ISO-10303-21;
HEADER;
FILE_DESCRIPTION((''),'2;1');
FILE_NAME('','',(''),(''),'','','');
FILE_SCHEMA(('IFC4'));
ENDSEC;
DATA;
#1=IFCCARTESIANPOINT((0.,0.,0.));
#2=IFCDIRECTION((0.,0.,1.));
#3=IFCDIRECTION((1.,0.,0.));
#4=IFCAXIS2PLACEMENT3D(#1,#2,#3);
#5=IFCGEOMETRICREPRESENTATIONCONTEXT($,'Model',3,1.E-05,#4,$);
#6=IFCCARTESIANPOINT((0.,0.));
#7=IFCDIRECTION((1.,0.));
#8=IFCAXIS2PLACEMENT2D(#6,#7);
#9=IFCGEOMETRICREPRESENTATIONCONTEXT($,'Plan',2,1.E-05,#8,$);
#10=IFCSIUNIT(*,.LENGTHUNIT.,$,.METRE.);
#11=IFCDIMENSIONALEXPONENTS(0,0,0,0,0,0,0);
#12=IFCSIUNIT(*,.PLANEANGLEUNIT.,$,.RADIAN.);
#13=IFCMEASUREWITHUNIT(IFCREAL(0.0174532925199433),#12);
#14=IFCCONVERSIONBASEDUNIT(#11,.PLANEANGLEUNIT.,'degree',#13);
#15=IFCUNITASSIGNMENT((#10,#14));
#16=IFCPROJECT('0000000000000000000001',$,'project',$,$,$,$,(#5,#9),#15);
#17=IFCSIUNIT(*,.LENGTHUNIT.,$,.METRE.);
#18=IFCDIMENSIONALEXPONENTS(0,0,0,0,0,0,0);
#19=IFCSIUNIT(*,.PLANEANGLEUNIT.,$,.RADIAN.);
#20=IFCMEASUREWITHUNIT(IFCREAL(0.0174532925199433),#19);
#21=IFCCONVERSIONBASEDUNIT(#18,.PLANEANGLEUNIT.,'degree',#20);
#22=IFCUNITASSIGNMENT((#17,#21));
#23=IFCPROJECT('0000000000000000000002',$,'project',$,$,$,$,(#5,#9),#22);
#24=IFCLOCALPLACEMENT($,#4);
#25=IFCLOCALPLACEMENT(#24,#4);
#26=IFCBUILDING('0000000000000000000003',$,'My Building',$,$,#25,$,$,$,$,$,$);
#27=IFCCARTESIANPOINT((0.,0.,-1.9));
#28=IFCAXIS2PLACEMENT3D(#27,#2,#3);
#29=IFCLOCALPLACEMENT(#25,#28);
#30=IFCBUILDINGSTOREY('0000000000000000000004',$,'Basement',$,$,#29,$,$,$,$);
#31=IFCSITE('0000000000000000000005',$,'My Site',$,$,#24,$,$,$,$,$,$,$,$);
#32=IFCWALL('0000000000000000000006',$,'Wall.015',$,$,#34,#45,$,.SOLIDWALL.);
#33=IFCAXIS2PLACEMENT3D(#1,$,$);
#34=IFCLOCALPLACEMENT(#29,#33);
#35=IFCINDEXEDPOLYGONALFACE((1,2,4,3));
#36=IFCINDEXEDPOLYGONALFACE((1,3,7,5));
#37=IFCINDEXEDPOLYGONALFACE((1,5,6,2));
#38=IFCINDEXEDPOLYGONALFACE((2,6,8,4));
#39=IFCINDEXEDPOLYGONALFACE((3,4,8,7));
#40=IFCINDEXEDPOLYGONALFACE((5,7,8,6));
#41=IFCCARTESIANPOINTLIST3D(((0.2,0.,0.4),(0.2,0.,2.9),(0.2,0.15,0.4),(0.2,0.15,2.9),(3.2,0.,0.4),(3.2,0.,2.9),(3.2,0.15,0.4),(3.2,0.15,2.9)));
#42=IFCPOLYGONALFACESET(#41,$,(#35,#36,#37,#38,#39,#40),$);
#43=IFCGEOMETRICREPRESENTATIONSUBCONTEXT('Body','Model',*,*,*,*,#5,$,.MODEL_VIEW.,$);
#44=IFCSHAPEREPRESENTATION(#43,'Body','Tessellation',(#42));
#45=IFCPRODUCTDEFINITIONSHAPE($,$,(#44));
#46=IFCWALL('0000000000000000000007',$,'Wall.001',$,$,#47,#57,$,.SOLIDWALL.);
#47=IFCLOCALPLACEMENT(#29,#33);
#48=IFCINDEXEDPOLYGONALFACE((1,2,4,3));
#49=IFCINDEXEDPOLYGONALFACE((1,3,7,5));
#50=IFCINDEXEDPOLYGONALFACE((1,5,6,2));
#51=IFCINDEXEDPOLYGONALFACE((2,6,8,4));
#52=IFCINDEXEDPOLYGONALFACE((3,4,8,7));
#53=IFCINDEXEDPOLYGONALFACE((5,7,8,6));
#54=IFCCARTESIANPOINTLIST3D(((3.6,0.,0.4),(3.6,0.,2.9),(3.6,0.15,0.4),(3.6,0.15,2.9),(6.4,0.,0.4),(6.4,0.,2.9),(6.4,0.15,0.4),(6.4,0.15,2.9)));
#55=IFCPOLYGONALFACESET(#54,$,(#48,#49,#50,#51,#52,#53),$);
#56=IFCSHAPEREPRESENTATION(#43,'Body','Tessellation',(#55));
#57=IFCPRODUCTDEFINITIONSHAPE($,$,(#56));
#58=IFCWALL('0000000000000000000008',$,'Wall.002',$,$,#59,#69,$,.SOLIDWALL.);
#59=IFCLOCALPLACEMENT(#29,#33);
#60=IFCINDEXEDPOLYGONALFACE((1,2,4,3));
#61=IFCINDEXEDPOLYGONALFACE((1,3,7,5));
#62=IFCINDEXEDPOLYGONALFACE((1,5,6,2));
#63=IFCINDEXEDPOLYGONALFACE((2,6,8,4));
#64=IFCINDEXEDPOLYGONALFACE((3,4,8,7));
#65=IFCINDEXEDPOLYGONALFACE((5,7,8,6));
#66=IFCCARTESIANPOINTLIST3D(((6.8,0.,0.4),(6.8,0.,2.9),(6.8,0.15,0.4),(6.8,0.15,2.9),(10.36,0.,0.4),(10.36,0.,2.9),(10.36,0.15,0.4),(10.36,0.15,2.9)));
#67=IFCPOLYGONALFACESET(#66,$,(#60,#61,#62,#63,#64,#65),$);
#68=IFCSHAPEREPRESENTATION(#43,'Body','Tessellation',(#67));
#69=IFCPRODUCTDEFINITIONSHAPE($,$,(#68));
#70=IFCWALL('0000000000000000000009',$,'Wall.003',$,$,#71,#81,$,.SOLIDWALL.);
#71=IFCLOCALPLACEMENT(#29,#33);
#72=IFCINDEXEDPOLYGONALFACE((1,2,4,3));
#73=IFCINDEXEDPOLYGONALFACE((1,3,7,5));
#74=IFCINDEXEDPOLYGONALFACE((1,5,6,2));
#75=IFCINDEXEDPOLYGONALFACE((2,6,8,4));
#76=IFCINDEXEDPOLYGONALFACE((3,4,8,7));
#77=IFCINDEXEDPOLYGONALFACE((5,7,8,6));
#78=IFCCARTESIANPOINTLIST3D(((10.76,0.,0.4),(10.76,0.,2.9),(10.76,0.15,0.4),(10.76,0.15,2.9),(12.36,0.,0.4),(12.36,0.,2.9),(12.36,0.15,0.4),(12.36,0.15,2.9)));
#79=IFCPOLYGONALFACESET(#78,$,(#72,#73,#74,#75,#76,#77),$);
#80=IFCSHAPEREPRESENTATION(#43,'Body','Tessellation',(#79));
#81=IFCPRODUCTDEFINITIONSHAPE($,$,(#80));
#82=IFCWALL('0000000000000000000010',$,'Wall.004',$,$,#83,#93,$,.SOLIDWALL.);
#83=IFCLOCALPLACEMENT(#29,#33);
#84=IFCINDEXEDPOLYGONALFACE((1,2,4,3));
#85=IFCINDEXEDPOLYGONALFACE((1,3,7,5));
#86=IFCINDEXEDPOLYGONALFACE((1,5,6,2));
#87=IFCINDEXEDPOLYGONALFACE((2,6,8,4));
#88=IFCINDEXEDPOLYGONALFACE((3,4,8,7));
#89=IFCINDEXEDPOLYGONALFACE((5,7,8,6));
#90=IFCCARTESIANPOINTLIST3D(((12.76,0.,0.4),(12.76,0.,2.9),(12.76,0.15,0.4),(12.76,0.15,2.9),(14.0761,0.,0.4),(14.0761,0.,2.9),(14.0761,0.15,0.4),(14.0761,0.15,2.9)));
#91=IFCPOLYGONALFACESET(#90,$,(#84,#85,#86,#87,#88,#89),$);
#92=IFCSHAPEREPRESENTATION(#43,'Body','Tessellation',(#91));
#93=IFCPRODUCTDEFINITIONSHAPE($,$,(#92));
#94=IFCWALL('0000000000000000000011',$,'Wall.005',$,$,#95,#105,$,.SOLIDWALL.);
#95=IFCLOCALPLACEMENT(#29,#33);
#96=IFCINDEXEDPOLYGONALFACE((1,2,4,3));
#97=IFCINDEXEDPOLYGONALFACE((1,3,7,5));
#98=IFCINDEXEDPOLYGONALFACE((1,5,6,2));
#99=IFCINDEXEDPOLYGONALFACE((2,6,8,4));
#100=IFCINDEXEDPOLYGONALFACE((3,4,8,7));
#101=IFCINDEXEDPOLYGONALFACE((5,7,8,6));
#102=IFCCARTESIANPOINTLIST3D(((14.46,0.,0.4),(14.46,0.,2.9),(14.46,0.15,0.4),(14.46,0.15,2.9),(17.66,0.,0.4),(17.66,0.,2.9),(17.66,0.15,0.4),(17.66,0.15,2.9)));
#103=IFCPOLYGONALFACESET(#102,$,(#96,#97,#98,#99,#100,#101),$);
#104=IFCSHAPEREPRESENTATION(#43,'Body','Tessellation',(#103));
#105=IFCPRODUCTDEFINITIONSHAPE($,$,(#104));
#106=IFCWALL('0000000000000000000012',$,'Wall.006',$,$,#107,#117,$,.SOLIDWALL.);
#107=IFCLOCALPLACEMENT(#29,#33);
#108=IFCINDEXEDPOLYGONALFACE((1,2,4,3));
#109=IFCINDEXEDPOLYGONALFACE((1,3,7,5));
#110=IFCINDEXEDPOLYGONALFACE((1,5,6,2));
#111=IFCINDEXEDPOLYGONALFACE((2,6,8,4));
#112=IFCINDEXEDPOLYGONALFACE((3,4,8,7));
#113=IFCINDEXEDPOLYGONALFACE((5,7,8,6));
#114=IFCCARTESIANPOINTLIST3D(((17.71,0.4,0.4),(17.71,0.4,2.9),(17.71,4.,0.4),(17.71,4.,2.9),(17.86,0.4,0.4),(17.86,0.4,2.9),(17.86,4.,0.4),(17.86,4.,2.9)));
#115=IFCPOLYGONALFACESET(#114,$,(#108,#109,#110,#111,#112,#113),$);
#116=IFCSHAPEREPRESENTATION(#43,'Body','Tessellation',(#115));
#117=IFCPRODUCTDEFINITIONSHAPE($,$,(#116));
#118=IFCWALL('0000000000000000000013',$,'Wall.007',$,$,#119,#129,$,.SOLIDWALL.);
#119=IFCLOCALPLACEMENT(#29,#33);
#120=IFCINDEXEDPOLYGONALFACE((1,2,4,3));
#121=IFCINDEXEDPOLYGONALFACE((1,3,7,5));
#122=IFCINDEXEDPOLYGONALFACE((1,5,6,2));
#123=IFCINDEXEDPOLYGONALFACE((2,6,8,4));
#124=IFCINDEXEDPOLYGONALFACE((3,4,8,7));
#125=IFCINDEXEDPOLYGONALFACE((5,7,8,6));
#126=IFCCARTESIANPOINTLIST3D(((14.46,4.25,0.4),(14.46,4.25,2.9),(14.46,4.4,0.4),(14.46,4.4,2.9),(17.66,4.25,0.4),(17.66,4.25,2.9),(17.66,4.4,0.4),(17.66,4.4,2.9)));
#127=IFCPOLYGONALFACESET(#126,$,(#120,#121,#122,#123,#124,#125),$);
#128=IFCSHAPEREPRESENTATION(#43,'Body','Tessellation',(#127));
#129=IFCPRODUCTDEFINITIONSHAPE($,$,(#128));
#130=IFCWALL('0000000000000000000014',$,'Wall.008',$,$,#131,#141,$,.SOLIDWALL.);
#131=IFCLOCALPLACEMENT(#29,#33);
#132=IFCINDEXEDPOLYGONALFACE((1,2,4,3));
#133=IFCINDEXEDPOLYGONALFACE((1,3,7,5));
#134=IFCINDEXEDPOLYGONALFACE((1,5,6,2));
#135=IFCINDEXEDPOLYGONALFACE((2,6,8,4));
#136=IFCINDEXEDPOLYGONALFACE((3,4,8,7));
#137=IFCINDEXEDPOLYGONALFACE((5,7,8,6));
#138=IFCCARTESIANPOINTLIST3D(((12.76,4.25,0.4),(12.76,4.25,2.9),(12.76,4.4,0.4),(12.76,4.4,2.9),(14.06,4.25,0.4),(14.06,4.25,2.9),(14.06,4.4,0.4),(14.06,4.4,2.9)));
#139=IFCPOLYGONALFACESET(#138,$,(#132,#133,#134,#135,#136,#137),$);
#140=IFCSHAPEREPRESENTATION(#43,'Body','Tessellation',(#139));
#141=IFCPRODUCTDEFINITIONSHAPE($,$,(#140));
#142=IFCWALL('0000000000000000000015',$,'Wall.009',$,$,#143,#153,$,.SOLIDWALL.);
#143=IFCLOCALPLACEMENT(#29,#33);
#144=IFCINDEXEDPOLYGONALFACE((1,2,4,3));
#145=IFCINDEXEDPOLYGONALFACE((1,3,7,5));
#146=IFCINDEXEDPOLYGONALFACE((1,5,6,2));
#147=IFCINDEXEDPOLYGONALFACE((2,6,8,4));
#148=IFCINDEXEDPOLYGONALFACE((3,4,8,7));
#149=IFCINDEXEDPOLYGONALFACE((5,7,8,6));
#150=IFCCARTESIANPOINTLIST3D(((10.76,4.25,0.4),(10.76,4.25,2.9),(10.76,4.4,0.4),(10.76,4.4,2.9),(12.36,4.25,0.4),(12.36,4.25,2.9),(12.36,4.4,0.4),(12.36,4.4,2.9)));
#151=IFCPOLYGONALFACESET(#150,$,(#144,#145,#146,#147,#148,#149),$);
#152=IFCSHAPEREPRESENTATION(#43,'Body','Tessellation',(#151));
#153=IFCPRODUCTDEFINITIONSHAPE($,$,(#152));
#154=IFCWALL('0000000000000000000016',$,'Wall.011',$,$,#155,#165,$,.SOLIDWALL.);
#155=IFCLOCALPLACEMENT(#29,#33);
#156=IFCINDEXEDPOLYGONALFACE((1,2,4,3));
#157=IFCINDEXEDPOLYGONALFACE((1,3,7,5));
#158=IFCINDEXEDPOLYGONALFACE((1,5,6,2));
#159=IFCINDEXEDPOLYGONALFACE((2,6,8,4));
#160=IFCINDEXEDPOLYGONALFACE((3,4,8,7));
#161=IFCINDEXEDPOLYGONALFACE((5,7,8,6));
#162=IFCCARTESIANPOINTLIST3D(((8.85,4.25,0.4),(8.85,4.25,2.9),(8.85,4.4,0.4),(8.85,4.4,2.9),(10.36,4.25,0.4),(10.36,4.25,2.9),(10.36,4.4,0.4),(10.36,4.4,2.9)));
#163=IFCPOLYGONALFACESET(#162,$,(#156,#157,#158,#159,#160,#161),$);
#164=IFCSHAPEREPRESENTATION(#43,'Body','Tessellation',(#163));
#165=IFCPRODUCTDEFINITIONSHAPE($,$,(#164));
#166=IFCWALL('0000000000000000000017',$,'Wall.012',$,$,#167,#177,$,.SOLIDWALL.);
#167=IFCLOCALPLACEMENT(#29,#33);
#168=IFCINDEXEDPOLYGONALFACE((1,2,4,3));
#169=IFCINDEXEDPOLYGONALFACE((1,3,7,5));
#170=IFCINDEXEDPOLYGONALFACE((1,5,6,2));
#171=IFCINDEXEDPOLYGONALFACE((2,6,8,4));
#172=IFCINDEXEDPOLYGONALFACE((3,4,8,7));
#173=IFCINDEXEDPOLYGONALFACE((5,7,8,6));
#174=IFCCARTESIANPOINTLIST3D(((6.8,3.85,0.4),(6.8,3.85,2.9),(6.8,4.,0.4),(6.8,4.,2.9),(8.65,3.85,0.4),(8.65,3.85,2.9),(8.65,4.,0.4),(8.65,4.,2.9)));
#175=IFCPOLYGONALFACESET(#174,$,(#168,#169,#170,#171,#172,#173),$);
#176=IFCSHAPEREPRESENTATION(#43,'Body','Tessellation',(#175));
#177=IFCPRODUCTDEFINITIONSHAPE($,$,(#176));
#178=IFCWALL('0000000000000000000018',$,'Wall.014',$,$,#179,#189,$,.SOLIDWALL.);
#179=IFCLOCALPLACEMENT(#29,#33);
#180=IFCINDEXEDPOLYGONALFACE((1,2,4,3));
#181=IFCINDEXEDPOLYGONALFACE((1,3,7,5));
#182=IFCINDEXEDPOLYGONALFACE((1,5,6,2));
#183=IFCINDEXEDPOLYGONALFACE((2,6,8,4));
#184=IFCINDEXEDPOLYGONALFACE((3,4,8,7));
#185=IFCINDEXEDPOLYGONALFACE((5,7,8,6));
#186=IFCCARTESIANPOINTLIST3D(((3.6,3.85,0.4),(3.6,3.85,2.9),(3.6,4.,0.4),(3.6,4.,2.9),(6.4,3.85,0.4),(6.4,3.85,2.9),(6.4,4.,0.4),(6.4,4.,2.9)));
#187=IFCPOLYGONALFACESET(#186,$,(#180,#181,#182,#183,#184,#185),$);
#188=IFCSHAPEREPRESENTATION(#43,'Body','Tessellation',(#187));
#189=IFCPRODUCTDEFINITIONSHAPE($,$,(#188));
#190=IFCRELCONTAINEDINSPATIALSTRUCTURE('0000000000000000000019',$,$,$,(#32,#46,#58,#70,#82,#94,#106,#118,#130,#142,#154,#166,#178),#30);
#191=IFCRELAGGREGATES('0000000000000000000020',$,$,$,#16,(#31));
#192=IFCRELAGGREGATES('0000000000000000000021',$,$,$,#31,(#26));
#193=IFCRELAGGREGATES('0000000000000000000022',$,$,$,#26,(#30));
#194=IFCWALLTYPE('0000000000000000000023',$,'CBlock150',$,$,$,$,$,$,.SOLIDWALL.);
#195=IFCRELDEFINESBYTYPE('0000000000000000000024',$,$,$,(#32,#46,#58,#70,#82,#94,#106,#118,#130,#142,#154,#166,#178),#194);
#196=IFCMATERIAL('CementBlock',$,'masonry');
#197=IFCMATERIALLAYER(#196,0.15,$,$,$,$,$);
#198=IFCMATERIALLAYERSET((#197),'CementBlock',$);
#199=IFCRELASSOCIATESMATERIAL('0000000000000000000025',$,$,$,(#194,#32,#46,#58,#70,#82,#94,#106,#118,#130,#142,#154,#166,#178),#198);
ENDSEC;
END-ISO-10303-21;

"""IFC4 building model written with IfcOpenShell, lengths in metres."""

from ifc_helpers import new_model, entity, si_unit, converted_unit, frame, origin_with_axes, origin_2d_with_axis, place, context, subcontext, project, spatial, indexed_curve, outline, extrude, material, layer, layer_set, layer_usage, type_object, element, save


model = new_model("IFC4")

# Units and contexts
model_context = context("Model", 3, precision=1e-05, world=origin_with_axes())
plan_context = context("Plan", 2, precision=1e-05, world=origin_2d_with_axis())
body_context = subcontext(model_context, "Body", "Model", "MODEL_VIEW")
ifc_project_1 = project(units=[si_unit("LENGTHUNIT", "METRE"), converted_unit("PLANEANGLEUNIT", "degree", entity("IfcReal", 0.0174532925199433), si_unit("PLANEANGLEUNIT", "RADIAN"), dimensions=[0, 0, 0, 0, 0, 0, 0])], contexts=[model_context, plan_context])
ifc_project_2 = project(units=[si_unit("LENGTHUNIT", "METRE"), converted_unit("PLANEANGLEUNIT", "degree", entity("IfcReal", 0.0174532925199433), si_unit("PLANEANGLEUNIT", "RADIAN"), dimensions=[0, 0, 0, 0, 0, 0, 0])], contexts=[model_context, plan_context])

# Site, building, storey
site_placement = place(None, origin_with_axes())
site = spatial("IfcSite", under=ifc_project_1, at=site_placement, Name="My Site")
building_placement = place(site_placement, origin_with_axes())
building = spatial("IfcBuilding", under=site, at=building_placement, Name="My Building")
storey_placement = place(building_placement, frame((0.0, 0.0, -1.9), z_axis=(0.0, 0.0, 1.0), x_axis=(1.0, 0.0, 0.0)))
storey = spatial("IfcBuildingStorey", under=building, at=storey_placement, Name="Basement")

# Walls
ifc_material_1 = material(Name="CementBlock", Category="masonry")
ifc_layer_1 = layer(ifc_material_1, 0.15)
ifc_layer_set_1 = layer_set([ifc_layer_1], Name="CementBlock")
ifc_layer_usage_1 = layer_usage(ifc_layer_set_1, "AXIS2", "POSITIVE", 0.0)
wall_type = type_object("IfcWallType", Name="CBlock150", PredefinedType="SOLIDWALL", material=ifc_layer_set_1)
wall_1_placement = place(storey_placement, frame((0.2, 0.0, 0.4), z_axis=(0.0, 0.0, 1.0), x_axis=(1.0, 0.0, 0.0)))
element("IfcWall", 1, at=wall_1_placement, inside=storey, type_object=wall_type, material=ifc_layer_usage_1, Name="Wall.015", PredefinedType="SOLIDWALL", context=body_context, shape_type="SweptSolid", body=[
    extrude(outline(indexed_curve([(0.0, 0.0), (0.0, 0.15), (3.0, 0.15), (3.0, 0.0), (0.0, 0.0)], self_intersect=False)), origin_with_axes(), (0.0, 0.0, 1.0), 2.5),
])
ifc_layer_usage_2 = layer_usage(ifc_layer_set_1, "AXIS2", "POSITIVE", 0.0)
wall_2_placement = place(storey_placement, frame((3.6, 0.0, 0.4), z_axis=(0.0, 0.0, 1.0), x_axis=(1.0, 0.0, 0.0)))
element("IfcWall", 2, at=wall_2_placement, inside=storey, type_object=wall_type, material=ifc_layer_usage_2, Name="Wall.001", PredefinedType="SOLIDWALL", context=body_context, shape_type="SweptSolid", body=[
    extrude(outline(indexed_curve([(0.0, 0.0), (0.0, 0.15), (2.8, 0.15), (2.8, 0.0), (0.0, 0.0)], self_intersect=False)), origin_with_axes(), (0.0, 0.0, 1.0), 2.5),
])
ifc_layer_usage_3 = layer_usage(ifc_layer_set_1, "AXIS2", "POSITIVE", 0.0)
wall_3_placement = place(storey_placement, frame((6.8, 0.0, 0.4), z_axis=(0.0, 0.0, 1.0), x_axis=(1.0, 0.0, 0.0)))
element("IfcWall", 3, at=wall_3_placement, inside=storey, type_object=wall_type, material=ifc_layer_usage_3, Name="Wall.002", PredefinedType="SOLIDWALL", context=body_context, shape_type="SweptSolid", body=[
    extrude(outline(indexed_curve([(0.0, 0.0), (0.0, 0.15), (3.56, 0.15), (3.56, 0.0), (0.0, 0.0)], self_intersect=False)), origin_with_axes(), (0.0, 0.0, 1.0), 2.5),
])
ifc_layer_usage_4 = layer_usage(ifc_layer_set_1, "AXIS2", "POSITIVE", 0.0)
wall_4_placement = place(storey_placement, frame((10.76, 0.0, 0.4), z_axis=(0.0, 0.0, 1.0), x_axis=(1.0, 0.0, 0.0)))
element("IfcWall", 4, at=wall_4_placement, inside=storey, type_object=wall_type, material=ifc_layer_usage_4, Name="Wall.003", PredefinedType="SOLIDWALL", context=body_context, shape_type="SweptSolid", body=[
    extrude(outline(indexed_curve([(0.0, 0.0), (0.0, 0.15), (1.6, 0.15), (1.6, 0.0), (0.0, 0.0)], self_intersect=False)), origin_with_axes(), (0.0, 0.0, 1.0), 2.5),
])
ifc_layer_usage_5 = layer_usage(ifc_layer_set_1, "AXIS2", "POSITIVE", 0.0)
wall_5_placement = place(storey_placement, frame((12.76, 0.0, 0.4), z_axis=(0.0, 0.0, 1.0), x_axis=(1.0, 0.0, 0.0)))
element("IfcWall", 5, at=wall_5_placement, inside=storey, type_object=wall_type, material=ifc_layer_usage_5, Name="Wall.004", PredefinedType="SOLIDWALL", context=body_context, shape_type="SweptSolid", body=[
    extrude(outline(indexed_curve([(0.0, 0.0), (0.0, 0.15), (1.3161, 0.15), (1.3161, 0.0), (0.0, 0.0)], self_intersect=False)), origin_with_axes(), (0.0, 0.0, 1.0), 2.5),
])
ifc_layer_usage_6 = layer_usage(ifc_layer_set_1, "AXIS2", "POSITIVE", 0.0)
wall_6_placement = place(storey_placement, frame((14.46, 0.0, 0.4), z_axis=(0.0, 0.0, 1.0), x_axis=(1.0, 0.0, 0.0)))
element("IfcWall", 6, at=wall_6_placement, inside=storey, type_object=wall_type, material=ifc_layer_usage_6, Name="Wall.005", PredefinedType="SOLIDWALL", context=body_context, shape_type="SweptSolid", body=[
    extrude(outline(indexed_curve([(0.0, 0.0), (0.0, 0.15), (3.2, 0.15), (3.2, 0.0), (0.0, 0.0)], self_intersect=False)), origin_with_axes(), (0.0, 0.0, 1.0), 2.5),
])
ifc_layer_usage_7 = layer_usage(ifc_layer_set_1, "AXIS2", "POSITIVE", 0.0)
wall_7_placement = place(storey_placement, frame((17.86, 0.4, 0.4), z_axis=(0.0, 0.0, 1.0), x_axis=(0.0, 1.0, 0.0)))
element("IfcWall", 7, at=wall_7_placement, inside=storey, type_object=wall_type, material=ifc_layer_usage_7, Name="Wall.006", PredefinedType="SOLIDWALL", context=body_context, shape_type="SweptSolid", body=[
    extrude(outline(indexed_curve([(0.0, 0.0), (0.0, 0.15), (3.6, 0.15), (3.6, 0.0), (0.0, 0.0)], self_intersect=False)), origin_with_axes(), (0.0, 0.0, 1.0), 2.5),
])
ifc_layer_usage_8 = layer_usage(ifc_layer_set_1, "AXIS2", "POSITIVE", 0.0)
wall_8_placement = place(storey_placement, frame((17.66, 4.4, 0.4), z_axis=(0.0, 0.0, 1.0), x_axis=(-1.0, 0.0, 0.0)))
element("IfcWall", 8, at=wall_8_placement, inside=storey, type_object=wall_type, material=ifc_layer_usage_8, Name="Wall.007", PredefinedType="SOLIDWALL", context=body_context, shape_type="SweptSolid", body=[
    extrude(outline(indexed_curve([(0.0, 0.0), (0.0, 0.15), (3.2, 0.15), (3.2, 0.0), (0.0, 0.0)], self_intersect=False)), origin_with_axes(), (0.0, 0.0, 1.0), 2.5),
])
ifc_layer_usage_9 = layer_usage(ifc_layer_set_1, "AXIS2", "POSITIVE", 0.0)
wall_9_placement = place(storey_placement, frame((14.06, 4.4, 0.4), z_axis=(0.0, 0.0, 1.0), x_axis=(-1.0, 0.0, 0.0)))
element("IfcWall", 9, at=wall_9_placement, inside=storey, type_object=wall_type, material=ifc_layer_usage_9, Name="Wall.008", PredefinedType="SOLIDWALL", context=body_context, shape_type="SweptSolid", body=[
    extrude(outline(indexed_curve([(0.0, 0.0), (0.0, 0.15), (1.3, 0.15), (1.3, 0.0), (0.0, 0.0)], self_intersect=False)), origin_with_axes(), (0.0, 0.0, 1.0), 2.5),
])
ifc_layer_usage_10 = layer_usage(ifc_layer_set_1, "AXIS2", "POSITIVE", 0.0)
wall_10_placement = place(storey_placement, frame((12.36, 4.4, 0.4), z_axis=(0.0, 0.0, 1.0), x_axis=(-1.0, 0.0, 0.0)))
element("IfcWall", 10, at=wall_10_placement, inside=storey, type_object=wall_type, material=ifc_layer_usage_10, Name="Wall.009", PredefinedType="SOLIDWALL", context=body_context, shape_type="SweptSolid", body=[
    extrude(outline(indexed_curve([(0.0, 0.0), (0.0, 0.15), (1.6, 0.15), (1.6, 0.0), (0.0, 0.0)], self_intersect=False)), origin_with_axes(), (0.0, 0.0, 1.0), 2.5),
])
ifc_layer_usage_11 = layer_usage(ifc_layer_set_1, "AXIS2", "POSITIVE", 0.0)
wall_11_placement = place(storey_placement, frame((10.36, 4.4, 0.4), z_axis=(0.0, 0.0, 1.0), x_axis=(-1.0, 0.0, 0.0)))
element("IfcWall", 11, at=wall_11_placement, inside=storey, type_object=wall_type, material=ifc_layer_usage_11, Name="Wall.011", PredefinedType="SOLIDWALL", context=body_context, shape_type="SweptSolid", body=[
    extrude(outline(indexed_curve([(0.0, 0.0), (0.0, 0.15), (1.51, 0.15), (1.51, 0.0), (0.0, 0.0)], self_intersect=False)), origin_with_axes(), (0.0, 0.0, 1.0), 2.5),
])
ifc_layer_usage_12 = layer_usage(ifc_layer_set_1, "AXIS2", "POSITIVE", 0.0)
wall_12_placement = place(storey_placement, frame((8.65, 4.0, 0.4), z_axis=(0.0, 0.0, 1.0), x_axis=(-1.0, 0.0, 0.0)))
element("IfcWall", 12, at=wall_12_placement, inside=storey, type_object=wall_type, material=ifc_layer_usage_12, Name="Wall.012", PredefinedType="SOLIDWALL", context=body_context, shape_type="SweptSolid", body=[
    extrude(outline(indexed_curve([(0.0, 0.0), (0.0, 0.15), (1.85, 0.15), (1.85, 0.0), (0.0, 0.0)], self_intersect=False)), origin_with_axes(), (0.0, 0.0, 1.0), 2.5),
])
ifc_layer_usage_13 = layer_usage(ifc_layer_set_1, "AXIS2", "POSITIVE", 0.0)
wall_13_placement = place(storey_placement, frame((6.4, 4.0, 0.4), z_axis=(0.0, 0.0, 1.0), x_axis=(-1.0, 0.0, 0.0)))
element("IfcWall", 13, at=wall_13_placement, inside=storey, type_object=wall_type, material=ifc_layer_usage_13, Name="Wall.014", PredefinedType="SOLIDWALL", context=body_context, shape_type="SweptSolid", body=[
    extrude(outline(indexed_curve([(0.0, 0.0), (0.0, 0.15), (2.8, 0.15), (2.8, 0.0), (0.0, 0.0)], self_intersect=False)), origin_with_axes(), (0.0, 0.0, 1.0), 2.5),
])

save(model, "model.ifc")
